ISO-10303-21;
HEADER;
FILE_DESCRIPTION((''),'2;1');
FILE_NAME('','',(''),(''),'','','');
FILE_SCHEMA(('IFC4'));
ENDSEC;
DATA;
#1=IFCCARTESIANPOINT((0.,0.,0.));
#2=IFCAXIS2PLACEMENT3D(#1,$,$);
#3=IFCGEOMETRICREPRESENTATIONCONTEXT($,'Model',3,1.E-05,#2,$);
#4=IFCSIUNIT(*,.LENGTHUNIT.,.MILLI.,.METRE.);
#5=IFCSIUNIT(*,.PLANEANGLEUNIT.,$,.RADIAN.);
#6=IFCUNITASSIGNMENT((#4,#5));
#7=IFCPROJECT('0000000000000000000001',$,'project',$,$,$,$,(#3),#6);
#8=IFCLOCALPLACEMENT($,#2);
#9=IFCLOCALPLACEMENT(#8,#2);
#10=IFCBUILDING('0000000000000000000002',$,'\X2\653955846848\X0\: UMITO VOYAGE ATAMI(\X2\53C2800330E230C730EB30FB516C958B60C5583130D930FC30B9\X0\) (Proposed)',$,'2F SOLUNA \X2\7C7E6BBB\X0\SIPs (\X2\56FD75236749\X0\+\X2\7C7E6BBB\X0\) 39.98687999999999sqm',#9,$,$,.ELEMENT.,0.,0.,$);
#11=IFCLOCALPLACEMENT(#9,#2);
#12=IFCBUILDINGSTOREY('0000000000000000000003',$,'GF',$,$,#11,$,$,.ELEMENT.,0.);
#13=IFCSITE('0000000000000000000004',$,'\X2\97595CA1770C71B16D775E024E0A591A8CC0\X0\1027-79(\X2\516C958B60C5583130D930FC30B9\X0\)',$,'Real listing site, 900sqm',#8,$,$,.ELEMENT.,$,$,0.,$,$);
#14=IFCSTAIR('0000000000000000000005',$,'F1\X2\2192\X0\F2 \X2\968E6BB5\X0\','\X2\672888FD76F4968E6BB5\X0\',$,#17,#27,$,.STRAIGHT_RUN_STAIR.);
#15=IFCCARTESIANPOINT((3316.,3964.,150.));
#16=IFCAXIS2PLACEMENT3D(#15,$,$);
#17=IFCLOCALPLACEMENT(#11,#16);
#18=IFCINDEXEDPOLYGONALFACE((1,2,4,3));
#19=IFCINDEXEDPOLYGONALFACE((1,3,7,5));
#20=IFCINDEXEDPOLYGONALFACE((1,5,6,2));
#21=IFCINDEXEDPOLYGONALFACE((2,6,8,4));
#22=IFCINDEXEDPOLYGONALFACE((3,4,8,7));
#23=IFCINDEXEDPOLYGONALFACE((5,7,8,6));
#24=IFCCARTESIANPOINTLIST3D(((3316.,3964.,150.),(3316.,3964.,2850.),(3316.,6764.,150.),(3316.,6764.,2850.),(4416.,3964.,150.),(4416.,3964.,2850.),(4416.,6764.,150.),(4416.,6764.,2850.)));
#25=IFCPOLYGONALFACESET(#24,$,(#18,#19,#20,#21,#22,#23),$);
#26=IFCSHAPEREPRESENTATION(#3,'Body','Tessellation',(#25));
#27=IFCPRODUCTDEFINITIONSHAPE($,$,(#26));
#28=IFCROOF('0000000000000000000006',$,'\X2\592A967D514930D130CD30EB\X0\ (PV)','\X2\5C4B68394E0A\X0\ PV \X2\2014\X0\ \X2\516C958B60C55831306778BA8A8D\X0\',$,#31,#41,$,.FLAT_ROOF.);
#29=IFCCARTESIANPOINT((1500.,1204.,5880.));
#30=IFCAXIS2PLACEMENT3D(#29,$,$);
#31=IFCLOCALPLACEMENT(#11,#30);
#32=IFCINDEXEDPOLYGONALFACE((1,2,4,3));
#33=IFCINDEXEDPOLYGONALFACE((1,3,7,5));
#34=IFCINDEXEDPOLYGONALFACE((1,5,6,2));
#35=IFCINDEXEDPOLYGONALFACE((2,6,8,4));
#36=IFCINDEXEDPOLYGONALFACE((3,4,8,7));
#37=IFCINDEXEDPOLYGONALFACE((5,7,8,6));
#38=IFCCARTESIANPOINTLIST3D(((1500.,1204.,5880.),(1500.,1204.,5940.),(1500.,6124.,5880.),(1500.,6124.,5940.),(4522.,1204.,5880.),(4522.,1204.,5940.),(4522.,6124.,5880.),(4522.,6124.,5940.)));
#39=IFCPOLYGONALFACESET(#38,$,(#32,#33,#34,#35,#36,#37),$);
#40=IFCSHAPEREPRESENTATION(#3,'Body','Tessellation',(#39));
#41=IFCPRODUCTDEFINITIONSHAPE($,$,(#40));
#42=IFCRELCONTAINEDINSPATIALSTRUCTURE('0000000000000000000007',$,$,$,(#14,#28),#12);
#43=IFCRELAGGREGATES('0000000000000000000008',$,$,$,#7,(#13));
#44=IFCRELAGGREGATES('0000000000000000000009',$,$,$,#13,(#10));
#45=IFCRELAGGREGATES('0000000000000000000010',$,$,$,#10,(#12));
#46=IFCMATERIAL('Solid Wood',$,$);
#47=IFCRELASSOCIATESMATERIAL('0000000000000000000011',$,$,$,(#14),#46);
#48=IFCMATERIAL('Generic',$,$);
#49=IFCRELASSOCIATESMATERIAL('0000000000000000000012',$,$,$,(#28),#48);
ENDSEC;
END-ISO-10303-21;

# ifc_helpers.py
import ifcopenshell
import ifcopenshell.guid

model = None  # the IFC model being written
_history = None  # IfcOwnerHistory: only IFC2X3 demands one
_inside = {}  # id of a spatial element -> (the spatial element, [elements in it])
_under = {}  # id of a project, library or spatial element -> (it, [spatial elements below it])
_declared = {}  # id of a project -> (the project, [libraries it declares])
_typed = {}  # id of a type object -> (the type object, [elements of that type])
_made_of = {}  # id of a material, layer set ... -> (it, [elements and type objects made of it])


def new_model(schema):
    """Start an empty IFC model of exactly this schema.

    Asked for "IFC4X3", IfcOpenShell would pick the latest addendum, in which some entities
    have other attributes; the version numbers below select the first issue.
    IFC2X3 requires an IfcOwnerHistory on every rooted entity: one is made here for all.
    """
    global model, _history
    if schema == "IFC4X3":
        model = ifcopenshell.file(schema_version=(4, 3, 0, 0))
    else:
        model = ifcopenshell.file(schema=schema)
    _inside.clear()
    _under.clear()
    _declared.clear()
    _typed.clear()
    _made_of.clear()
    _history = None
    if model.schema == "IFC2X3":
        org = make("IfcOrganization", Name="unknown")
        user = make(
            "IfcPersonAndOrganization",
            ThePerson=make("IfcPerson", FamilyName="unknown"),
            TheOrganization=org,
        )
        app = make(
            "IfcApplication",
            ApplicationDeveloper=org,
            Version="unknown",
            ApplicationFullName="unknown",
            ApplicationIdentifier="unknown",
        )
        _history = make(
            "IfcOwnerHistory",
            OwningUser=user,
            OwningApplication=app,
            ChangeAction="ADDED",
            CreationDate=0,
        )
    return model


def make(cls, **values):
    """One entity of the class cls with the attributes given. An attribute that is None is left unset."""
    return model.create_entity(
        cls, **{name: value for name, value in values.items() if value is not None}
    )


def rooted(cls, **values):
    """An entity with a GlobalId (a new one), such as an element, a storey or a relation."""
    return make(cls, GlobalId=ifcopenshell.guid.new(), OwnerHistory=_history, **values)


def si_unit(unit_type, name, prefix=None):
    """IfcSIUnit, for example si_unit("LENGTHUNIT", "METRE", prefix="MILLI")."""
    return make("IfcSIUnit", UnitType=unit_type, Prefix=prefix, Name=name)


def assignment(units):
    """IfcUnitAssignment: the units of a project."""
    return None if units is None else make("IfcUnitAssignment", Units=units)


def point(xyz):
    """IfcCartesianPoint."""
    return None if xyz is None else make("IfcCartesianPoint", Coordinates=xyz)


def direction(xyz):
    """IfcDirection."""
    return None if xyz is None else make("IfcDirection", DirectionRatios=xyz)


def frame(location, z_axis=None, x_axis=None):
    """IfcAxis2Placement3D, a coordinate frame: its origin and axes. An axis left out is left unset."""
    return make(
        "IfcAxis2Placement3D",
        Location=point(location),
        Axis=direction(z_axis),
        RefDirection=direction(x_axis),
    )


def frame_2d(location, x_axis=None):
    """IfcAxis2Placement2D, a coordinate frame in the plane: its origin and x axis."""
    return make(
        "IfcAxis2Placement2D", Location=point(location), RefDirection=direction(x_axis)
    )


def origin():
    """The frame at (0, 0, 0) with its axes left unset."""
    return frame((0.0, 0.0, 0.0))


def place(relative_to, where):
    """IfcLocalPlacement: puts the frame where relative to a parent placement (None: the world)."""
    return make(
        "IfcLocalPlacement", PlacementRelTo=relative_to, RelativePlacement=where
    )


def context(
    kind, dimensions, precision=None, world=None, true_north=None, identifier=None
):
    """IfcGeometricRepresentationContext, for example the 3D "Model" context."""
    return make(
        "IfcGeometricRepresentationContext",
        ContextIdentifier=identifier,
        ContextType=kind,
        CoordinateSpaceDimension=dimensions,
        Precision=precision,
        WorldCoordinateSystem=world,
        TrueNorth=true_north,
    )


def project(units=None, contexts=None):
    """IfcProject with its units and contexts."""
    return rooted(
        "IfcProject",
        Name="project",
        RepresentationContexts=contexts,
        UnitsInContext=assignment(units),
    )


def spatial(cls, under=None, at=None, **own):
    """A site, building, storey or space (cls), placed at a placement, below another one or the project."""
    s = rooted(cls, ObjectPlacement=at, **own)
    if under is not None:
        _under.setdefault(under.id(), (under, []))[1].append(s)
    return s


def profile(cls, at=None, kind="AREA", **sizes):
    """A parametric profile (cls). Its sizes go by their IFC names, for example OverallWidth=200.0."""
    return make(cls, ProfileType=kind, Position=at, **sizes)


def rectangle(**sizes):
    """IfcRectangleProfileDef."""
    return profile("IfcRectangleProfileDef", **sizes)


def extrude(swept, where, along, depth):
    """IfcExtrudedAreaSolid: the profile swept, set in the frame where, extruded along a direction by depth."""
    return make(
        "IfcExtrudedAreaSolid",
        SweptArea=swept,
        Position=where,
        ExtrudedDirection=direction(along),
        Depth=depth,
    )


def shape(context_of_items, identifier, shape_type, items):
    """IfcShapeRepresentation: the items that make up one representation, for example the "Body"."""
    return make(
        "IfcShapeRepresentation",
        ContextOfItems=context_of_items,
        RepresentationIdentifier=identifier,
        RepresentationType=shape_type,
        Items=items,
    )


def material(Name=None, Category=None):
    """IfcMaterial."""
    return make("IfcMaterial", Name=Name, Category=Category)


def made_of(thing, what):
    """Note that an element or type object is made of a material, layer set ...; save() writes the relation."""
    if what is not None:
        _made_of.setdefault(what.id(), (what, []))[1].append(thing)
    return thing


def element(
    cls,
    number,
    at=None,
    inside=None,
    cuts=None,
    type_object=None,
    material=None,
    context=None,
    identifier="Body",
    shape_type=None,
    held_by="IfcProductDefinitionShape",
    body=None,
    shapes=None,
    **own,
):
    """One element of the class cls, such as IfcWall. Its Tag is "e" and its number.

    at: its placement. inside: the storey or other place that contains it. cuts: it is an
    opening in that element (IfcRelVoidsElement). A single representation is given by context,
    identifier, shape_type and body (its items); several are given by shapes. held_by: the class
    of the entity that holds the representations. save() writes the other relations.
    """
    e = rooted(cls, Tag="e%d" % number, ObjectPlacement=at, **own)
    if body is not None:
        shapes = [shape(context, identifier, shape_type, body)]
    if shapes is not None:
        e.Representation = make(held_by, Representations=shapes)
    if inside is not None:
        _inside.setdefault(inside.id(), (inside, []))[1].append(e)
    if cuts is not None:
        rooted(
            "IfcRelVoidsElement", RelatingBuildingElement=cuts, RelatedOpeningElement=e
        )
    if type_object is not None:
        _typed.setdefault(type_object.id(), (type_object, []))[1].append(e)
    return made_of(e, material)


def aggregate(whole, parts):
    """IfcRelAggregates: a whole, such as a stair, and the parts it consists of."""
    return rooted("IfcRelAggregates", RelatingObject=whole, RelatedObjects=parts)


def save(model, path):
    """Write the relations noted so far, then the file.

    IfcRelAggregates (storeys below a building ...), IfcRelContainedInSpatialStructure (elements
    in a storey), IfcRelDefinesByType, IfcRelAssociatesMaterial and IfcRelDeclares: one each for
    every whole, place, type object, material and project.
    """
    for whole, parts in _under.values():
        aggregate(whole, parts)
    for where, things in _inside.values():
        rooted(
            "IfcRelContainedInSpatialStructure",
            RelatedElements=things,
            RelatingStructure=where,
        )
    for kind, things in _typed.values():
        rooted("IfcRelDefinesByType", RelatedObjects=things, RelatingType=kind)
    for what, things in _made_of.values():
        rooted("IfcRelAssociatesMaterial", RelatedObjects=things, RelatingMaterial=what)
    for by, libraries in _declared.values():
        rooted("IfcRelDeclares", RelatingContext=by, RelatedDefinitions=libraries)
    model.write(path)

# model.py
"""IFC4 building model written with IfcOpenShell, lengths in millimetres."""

from ifc_helpers import new_model, si_unit, frame, frame_2d, origin, place, context, project, spatial, rectangle, extrude, material, element, save


model = new_model("IFC4")

# Units and contexts
model_context = context("Model", 3, precision=1e-05, world=origin())
ifc_project = project(units=[si_unit("LENGTHUNIT", "METRE", prefix="MILLI"), si_unit("PLANEANGLEUNIT", "RADIAN")], contexts=[model_context])

# Site, building, storey
site_placement = place(None, origin())
site = spatial("IfcSite", under=ifc_project, at=site_placement, Name="静岡県熱海市上多賀1027-79(公開情報ベース)", ObjectType="Real listing site, 900sqm", CompositionType="ELEMENT", RefElevation=0.0)
building_placement = place(site_placement, origin())
building = spatial("IfcBuilding", under=site, at=building_placement, Name="改善案: UMITO VOYAGE ATAMI(参考モデル・公開情報ベース) (Proposed)", ObjectType="2F SOLUNA 籾殻SIPs (国産杉+籾殻) 39.98687999999999sqm", CompositionType="ELEMENT", ElevationOfRefHeight=0.0, ElevationOfTerrain=0.0)
storey_placement = place(building_placement, origin())
storey = spatial("IfcBuildingStorey", under=building, at=storey_placement, Name="GF", CompositionType="ELEMENT", Elevation=0.0)

# Shared definitions
ifc_material_1 = material(Name="Generic")

# Stair
ifc_material_2 = material(Name="Solid Wood")
stair_placement = place(storey_placement, frame((3316.0, 3964.0, 150.0)))
element("IfcStair", 1, at=stair_placement, inside=storey, material=ifc_material_2, Name="F1→F2 階段", Description="木製直階段", PredefinedType="STRAIGHT_RUN_STAIR", context=model_context, shape_type="SweptSolid", body=[
    extrude(rectangle(XDim=1100.0, YDim=2800.0, at=frame_2d((550.0, 1400.0))), frame((3316.0, 3964.0, 150.0)), (0.0, 0.0, 1.0), 2700.0),
])

# Roof
roof_placement = place(storey_placement, frame((1500.0, 1204.0, 5880.0)))
element("IfcRoof", 2, at=roof_placement, inside=storey, material=ifc_material_1, Name="太陽光パネル (PV)", Description="屋根上 PV — 公開情報で確認", PredefinedType="FLAT_ROOF", context=model_context, shape_type="SweptSolid", body=[
    extrude(rectangle(XDim=3022.0, YDim=4920.0, at=frame_2d((1511.0, 2460.0))), frame((1500.0, 1204.0, 5880.0)), (0.0, 0.0, 1.0), 60.0),
])

save(model, "model.ifc")
